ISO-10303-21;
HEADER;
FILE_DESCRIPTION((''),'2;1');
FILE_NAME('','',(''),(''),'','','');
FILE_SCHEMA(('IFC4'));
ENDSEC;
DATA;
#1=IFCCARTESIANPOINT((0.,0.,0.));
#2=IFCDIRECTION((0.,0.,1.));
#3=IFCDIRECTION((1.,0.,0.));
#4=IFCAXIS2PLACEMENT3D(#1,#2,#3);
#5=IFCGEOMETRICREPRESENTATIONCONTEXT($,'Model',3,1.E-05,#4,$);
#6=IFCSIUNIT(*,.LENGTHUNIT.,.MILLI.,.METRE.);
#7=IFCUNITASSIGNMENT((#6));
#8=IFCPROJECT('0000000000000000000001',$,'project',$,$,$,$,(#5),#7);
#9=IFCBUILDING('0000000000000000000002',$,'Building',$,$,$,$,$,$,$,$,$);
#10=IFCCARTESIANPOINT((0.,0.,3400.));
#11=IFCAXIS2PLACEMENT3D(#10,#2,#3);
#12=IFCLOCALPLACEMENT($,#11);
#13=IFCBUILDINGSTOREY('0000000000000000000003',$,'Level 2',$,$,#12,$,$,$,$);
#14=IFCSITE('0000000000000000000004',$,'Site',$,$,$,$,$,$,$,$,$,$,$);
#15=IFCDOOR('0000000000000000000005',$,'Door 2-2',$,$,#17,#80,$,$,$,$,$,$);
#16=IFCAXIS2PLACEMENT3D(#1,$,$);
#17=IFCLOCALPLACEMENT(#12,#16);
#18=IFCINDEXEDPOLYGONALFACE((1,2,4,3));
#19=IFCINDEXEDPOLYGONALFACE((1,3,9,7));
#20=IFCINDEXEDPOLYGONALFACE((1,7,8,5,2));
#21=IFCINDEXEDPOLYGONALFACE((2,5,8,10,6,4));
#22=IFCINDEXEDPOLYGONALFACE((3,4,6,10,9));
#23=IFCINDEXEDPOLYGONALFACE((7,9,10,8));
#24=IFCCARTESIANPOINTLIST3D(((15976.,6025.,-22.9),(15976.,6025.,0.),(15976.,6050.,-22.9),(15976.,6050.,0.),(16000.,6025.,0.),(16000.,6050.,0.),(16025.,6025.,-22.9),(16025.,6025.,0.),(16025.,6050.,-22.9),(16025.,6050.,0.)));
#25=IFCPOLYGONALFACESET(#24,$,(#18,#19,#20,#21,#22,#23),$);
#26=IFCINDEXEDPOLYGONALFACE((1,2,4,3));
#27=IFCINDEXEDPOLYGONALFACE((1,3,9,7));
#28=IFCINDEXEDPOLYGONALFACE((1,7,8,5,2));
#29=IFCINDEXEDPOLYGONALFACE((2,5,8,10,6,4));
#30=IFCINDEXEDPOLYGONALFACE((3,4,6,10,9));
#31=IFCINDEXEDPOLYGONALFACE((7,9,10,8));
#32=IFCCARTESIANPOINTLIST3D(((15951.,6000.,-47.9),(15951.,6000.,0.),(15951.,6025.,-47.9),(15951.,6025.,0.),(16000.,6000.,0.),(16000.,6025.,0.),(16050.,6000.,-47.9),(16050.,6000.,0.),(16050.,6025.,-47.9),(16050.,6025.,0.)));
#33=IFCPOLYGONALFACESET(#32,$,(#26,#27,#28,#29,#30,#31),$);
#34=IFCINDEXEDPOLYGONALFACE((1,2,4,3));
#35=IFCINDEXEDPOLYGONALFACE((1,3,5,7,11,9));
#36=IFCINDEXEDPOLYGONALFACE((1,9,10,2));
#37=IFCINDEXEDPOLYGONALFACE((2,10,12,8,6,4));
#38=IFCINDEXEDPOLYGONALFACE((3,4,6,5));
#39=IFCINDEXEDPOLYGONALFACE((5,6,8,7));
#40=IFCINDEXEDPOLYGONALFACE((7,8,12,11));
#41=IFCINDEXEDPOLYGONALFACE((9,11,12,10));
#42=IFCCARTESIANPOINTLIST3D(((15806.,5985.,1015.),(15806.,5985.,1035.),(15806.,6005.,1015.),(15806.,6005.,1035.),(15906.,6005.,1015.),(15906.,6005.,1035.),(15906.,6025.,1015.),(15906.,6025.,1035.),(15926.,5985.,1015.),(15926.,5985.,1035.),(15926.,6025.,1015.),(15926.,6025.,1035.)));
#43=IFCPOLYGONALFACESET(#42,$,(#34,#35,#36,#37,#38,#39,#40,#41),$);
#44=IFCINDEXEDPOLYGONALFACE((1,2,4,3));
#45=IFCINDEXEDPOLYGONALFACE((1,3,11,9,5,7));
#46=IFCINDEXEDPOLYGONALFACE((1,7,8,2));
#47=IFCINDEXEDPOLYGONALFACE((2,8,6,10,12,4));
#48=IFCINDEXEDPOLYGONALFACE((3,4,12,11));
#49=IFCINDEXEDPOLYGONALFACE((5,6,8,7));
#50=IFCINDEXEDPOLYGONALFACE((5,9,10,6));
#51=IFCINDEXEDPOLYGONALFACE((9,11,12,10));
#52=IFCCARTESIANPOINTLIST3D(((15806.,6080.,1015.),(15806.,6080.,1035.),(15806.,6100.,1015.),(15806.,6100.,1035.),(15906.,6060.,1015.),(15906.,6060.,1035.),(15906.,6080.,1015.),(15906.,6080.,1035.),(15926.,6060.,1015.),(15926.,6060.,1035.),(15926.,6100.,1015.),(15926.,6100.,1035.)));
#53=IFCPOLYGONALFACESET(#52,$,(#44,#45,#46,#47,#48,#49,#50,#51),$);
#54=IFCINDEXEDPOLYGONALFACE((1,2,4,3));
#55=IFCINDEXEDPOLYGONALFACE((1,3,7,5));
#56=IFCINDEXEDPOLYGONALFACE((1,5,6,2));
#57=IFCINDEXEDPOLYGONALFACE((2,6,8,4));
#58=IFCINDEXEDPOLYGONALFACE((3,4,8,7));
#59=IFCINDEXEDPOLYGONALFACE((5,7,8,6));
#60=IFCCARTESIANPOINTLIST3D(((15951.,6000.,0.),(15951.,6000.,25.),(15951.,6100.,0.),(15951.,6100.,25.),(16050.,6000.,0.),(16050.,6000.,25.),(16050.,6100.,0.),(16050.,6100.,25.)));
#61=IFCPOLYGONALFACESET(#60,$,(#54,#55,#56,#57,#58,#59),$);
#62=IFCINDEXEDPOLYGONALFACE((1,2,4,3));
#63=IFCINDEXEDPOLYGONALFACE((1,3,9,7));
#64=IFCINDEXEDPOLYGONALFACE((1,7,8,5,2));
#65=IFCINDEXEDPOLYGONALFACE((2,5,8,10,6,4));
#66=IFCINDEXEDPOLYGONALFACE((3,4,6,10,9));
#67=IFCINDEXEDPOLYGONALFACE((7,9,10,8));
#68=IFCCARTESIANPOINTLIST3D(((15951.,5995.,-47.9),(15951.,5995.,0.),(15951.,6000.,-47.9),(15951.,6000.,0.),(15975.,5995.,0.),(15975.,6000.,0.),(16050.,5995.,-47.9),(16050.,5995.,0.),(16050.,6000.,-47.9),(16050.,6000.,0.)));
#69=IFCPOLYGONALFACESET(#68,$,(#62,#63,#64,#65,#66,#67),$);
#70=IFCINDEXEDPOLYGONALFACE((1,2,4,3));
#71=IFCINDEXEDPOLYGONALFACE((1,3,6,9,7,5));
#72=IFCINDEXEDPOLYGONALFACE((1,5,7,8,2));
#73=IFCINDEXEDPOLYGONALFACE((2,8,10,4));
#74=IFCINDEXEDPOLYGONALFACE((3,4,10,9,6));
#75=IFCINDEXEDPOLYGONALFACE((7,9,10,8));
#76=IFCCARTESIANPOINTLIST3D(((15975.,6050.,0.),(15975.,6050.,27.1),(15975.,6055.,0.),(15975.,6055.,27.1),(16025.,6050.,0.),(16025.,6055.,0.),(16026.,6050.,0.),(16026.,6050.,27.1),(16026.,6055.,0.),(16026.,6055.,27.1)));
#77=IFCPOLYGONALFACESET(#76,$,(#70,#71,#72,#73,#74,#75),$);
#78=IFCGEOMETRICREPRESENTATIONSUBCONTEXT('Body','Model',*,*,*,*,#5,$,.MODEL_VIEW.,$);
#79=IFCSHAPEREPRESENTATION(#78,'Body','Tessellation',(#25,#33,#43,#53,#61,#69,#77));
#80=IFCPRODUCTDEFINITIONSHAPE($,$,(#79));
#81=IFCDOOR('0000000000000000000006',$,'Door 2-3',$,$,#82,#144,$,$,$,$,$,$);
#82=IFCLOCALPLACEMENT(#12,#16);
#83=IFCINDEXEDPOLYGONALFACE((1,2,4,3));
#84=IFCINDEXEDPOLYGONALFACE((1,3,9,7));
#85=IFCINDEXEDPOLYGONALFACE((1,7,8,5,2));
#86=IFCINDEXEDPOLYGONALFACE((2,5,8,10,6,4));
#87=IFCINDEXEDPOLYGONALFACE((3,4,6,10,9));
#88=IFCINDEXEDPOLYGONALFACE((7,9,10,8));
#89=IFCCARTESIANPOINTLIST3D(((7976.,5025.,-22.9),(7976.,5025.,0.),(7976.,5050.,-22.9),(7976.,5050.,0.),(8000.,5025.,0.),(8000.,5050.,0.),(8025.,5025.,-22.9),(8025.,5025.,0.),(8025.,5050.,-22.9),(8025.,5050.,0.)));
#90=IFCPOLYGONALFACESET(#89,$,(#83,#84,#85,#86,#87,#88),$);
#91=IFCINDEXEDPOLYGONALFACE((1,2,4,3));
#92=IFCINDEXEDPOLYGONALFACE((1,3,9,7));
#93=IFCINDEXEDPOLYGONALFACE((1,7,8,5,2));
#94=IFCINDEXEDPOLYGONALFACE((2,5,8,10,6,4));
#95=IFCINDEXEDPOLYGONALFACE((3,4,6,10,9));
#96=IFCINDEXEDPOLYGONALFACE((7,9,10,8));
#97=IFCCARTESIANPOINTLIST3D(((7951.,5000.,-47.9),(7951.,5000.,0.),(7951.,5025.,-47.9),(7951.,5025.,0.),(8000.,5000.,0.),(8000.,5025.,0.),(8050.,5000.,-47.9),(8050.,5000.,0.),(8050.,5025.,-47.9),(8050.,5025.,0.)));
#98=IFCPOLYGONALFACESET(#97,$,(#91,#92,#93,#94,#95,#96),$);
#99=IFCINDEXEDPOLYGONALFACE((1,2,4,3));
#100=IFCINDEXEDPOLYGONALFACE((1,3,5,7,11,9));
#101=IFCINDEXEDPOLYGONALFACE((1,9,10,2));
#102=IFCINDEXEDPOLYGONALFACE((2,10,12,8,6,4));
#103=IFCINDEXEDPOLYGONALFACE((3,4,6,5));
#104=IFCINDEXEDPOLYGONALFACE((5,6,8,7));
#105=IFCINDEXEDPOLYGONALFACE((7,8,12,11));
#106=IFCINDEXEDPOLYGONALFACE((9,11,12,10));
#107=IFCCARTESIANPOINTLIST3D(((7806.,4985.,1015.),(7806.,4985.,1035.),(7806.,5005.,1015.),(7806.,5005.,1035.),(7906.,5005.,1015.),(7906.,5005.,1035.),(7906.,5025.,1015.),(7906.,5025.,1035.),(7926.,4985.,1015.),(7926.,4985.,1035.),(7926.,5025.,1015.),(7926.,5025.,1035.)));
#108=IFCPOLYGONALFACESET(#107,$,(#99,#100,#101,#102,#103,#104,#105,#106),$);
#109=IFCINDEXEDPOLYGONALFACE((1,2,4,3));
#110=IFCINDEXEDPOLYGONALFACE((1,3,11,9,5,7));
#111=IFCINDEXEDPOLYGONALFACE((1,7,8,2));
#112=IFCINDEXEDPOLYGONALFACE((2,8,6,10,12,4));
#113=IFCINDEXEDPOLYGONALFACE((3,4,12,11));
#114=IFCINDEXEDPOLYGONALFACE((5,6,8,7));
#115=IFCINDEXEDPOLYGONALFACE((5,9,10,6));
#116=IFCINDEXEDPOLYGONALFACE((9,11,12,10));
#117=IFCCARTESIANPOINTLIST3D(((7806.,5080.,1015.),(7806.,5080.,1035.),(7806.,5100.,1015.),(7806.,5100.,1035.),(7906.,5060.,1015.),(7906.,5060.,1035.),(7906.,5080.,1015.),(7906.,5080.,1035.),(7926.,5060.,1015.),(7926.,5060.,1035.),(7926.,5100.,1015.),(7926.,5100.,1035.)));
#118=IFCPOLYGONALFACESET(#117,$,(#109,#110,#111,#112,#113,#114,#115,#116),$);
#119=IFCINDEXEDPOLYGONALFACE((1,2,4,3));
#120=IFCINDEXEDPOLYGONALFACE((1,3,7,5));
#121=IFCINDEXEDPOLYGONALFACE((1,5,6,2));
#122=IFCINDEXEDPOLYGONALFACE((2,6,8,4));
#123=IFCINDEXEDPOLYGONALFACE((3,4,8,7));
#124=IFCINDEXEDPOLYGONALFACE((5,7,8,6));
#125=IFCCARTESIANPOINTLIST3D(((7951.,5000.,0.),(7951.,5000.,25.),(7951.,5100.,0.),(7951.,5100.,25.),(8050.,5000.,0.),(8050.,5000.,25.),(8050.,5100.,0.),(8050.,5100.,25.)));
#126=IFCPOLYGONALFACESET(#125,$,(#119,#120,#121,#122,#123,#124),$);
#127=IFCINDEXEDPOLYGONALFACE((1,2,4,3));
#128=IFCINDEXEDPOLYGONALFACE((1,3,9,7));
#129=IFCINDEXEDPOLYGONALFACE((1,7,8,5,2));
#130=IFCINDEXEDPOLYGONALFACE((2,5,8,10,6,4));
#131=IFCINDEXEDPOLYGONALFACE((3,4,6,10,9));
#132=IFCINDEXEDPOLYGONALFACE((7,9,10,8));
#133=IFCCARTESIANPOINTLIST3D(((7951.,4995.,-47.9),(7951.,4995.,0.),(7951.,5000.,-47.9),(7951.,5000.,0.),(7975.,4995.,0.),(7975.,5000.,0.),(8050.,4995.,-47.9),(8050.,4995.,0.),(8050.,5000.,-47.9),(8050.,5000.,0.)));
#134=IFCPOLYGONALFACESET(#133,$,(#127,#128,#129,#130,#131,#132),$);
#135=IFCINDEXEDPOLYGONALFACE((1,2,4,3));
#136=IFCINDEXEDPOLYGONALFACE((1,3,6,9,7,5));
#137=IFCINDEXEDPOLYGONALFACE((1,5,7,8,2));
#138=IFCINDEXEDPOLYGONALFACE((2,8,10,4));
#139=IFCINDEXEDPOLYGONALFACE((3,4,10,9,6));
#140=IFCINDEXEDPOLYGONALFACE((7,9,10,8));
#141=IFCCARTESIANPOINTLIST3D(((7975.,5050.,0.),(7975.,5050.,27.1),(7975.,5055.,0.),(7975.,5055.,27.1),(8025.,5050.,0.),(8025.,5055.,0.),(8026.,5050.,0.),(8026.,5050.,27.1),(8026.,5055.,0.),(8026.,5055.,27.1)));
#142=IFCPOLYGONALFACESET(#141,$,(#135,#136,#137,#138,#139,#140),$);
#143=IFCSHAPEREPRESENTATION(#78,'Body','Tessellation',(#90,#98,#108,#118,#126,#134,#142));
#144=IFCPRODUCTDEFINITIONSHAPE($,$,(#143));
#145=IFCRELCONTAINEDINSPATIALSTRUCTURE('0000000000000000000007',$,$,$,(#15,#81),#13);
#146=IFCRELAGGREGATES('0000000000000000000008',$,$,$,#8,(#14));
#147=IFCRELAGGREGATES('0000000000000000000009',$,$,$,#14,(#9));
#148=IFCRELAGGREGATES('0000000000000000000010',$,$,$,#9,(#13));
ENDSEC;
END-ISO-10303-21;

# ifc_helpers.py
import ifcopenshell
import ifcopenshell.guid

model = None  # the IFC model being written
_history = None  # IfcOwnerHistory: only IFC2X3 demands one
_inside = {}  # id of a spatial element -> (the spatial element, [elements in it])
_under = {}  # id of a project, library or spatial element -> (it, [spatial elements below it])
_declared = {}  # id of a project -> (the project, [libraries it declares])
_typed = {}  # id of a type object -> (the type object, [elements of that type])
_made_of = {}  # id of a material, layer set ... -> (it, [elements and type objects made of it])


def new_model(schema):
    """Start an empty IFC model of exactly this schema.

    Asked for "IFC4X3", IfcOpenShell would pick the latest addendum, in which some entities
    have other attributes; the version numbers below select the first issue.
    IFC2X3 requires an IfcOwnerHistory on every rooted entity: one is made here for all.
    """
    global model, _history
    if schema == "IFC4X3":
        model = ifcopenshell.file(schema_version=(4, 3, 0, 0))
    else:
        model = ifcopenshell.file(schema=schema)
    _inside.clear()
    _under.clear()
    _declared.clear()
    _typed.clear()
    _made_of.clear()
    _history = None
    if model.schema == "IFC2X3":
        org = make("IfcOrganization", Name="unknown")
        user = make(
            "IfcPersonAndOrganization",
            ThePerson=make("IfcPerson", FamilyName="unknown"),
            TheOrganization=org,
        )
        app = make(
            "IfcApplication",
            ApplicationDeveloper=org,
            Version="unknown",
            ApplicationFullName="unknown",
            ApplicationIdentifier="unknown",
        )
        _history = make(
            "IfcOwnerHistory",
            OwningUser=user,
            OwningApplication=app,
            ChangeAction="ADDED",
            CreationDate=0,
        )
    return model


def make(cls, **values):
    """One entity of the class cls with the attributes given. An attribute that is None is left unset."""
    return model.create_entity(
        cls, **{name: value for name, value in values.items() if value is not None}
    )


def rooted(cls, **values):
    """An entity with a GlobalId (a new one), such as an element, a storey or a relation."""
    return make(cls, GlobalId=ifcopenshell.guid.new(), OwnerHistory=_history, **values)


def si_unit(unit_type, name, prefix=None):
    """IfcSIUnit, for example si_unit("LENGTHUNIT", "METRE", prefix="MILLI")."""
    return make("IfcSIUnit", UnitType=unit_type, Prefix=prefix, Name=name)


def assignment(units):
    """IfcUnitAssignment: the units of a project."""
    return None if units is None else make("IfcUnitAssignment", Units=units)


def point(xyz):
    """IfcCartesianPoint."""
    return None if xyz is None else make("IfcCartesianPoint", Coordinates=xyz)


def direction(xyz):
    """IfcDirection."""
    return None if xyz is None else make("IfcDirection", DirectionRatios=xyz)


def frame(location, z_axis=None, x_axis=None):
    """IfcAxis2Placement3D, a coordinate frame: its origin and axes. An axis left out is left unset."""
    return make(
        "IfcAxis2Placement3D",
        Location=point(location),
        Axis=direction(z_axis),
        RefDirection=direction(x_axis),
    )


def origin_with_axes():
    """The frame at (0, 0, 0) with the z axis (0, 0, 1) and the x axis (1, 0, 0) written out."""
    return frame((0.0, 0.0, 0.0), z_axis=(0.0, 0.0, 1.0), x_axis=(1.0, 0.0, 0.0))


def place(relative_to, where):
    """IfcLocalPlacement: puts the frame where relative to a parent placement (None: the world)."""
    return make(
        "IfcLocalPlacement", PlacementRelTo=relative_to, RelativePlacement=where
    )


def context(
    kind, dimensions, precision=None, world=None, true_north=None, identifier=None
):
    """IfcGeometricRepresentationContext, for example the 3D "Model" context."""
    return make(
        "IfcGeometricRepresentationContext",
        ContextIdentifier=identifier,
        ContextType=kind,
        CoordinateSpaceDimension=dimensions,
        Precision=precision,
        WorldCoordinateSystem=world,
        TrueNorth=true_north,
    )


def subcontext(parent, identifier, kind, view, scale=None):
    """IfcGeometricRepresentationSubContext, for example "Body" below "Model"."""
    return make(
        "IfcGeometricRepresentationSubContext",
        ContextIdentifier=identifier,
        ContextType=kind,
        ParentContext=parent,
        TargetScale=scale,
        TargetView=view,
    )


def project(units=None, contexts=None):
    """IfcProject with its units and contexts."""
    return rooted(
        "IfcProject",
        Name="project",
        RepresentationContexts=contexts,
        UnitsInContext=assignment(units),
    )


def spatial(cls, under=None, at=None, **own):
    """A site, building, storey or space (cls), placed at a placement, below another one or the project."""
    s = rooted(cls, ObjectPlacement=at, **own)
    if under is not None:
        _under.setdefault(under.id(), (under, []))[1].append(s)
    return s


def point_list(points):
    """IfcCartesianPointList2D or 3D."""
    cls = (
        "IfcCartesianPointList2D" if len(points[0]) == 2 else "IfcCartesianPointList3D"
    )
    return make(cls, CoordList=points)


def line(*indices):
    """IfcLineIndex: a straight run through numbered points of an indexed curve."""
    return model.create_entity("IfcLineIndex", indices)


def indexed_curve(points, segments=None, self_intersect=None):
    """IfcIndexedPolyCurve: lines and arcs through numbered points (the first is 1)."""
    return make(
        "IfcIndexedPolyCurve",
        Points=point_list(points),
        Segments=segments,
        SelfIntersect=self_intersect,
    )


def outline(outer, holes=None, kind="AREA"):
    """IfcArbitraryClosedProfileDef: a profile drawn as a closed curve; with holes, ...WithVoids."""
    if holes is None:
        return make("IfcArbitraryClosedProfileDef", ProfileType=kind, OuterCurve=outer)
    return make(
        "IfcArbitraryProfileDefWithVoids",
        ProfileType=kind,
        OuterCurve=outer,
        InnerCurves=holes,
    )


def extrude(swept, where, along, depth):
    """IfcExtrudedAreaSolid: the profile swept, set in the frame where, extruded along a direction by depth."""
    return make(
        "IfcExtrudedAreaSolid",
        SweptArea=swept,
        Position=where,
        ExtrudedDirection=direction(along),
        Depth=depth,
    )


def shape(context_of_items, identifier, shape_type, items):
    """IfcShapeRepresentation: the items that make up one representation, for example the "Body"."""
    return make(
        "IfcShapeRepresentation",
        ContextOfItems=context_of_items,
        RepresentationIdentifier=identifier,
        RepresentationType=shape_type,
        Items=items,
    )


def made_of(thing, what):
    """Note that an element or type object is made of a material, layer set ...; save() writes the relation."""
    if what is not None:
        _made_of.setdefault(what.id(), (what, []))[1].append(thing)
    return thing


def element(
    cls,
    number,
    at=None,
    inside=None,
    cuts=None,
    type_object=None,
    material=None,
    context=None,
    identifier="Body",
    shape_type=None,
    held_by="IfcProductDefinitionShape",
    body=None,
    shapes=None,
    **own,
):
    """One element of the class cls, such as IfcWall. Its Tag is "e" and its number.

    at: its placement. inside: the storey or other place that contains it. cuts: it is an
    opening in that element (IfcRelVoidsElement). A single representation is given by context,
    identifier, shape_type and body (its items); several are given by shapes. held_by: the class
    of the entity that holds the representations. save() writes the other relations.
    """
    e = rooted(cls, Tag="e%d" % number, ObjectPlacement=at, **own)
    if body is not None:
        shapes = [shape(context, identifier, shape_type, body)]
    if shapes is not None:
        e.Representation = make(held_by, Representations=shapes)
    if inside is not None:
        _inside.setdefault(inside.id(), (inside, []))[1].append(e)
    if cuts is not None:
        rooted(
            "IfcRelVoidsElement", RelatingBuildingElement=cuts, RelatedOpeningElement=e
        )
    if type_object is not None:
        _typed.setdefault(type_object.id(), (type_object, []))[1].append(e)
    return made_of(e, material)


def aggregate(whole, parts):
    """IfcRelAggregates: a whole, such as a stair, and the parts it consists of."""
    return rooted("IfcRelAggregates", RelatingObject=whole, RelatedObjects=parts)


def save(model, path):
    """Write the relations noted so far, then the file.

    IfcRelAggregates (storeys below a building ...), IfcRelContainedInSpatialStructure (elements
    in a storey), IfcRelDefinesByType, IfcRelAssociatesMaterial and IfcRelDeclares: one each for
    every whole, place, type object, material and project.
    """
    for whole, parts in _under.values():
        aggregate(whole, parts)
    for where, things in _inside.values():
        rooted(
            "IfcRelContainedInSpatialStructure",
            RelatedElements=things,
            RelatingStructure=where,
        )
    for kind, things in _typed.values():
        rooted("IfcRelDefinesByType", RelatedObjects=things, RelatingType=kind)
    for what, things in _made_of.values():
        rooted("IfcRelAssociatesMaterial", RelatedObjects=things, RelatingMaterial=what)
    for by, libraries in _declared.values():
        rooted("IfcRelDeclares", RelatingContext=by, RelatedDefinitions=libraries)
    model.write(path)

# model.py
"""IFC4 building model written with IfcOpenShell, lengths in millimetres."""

from ifc_helpers import new_model, si_unit, frame, origin_with_axes, place, context, subcontext, project, spatial, line, indexed_curve, outline, extrude, element, save


model = new_model("IFC4")

# Units and contexts
model_context = context("Model", 3, precision=1e-05, world=origin_with_axes())
body_context = subcontext(model_context, "Body", "Model", "MODEL_VIEW")
ifc_project = project(units=[si_unit("LENGTHUNIT", "METRE", prefix="MILLI")], contexts=[model_context])

# Site, building, storey
site = spatial("IfcSite", under=ifc_project, Name="Site")
building = spatial("IfcBuilding", under=site, Name="Building")
storey_placement = place(None, frame((0.0, 0.0, 3400.0), z_axis=(0.0, 0.0, 1.0), x_axis=(1.0, 0.0, 0.0)))
storey = spatial("IfcBuildingStorey", under=building, at=storey_placement, Name="Level 2")

# Doors
door_1_placement = place(storey_placement, frame((16000.0, 6000.0, 0.0), z_axis=(0.0, 0.0, 1.0), x_axis=(1.0, 0.0, 0.0)))
element("IfcDoor", 1, at=door_1_placement, inside=storey, Name="Door 2-2", context=body_context, shape_type="SweptSolid", body=[
    extrude(outline(indexed_curve([(0.0, 0.0), (0.0, 2.1), (1.0, 2.1), (1.0, 0.0), (-24.0, 0.0), (-24.0, -22.9), (25.0, -22.9), (25.0, 0.0)], segments=[line(1, 2, 3, 4, 5, 6, 7, 8, 1)])), frame((0.0, 25.0, 0.0), z_axis=(0.0, -1.0, 0.0), x_axis=(1.0, 0.0, 0.0)), (0.0, 0.0, -1.0), 25.0),
    extrude(outline(indexed_curve([(0.0, 0.0), (0.0, 2.1), (1.0, 2.1), (1.0, 0.0), (-49.0, 0.0), (-49.0, -47.9), (50.0, -47.9), (50.0, 0.0)], segments=[line(1, 2, 3, 4, 5, 6, 7, 8, 1)])), frame((0.0, 0.0, 0.0), z_axis=(0.0, -1.0, 0.0), x_axis=(1.0, 0.0, 0.0)), (0.0, 0.0, -1.0), 25.0),
    extrude(outline(indexed_curve([(0.0, 0.0), (-49.0, 0.0), (-49.0, 35.0), (0.0, 35.0)], segments=[line(1, 2, 3, 4, 1)])), frame((25.0, 25.0, 25.0), z_axis=(0.0, 0.0, 1.0), x_axis=(1.0, 0.0, 0.0)), (0.0, 0.0, 1.0), -47.9),
    extrude(outline(indexed_curve([(0.0, 0.0), (0.0, -40.0), (-120.0, -40.0), (-120.0, -20.0), (-20.0, -20.0), (-20.0, 0.0)], segments=[line(1, 2, 3, 4, 5, 6, 1)])), frame((-74.0, 25.0, 1015.0), z_axis=(0.0, 0.0, 1.0), x_axis=(1.0, 0.0, 0.0)), (0.0, 0.0, 1.0), 20.0),
    extrude(outline(indexed_curve([(0.0, 0.0), (0.0, 40.0), (-120.0, 40.0), (-120.0, 20.0), (-20.0, 20.0), (-20.0, 0.0)], segments=[line(1, 2, 3, 4, 5, 6, 1)])), frame((-74.0, 60.0, 1015.0), z_axis=(0.0, 0.0, 1.0), x_axis=(1.0, 0.0, 0.0)), (0.0, 0.0, 1.0), 20.0),
    extrude(outline(indexed_curve([(0.0, 0.0), (-99.0, 0.0), (-99.0, 100.0), (0.0, 100.0)], segments=[line(1, 2, 3, 4, 1)])), frame((50.0, 0.0, 0.0), z_axis=(0.0, 0.0, 1.0), x_axis=(1.0, 0.0, 0.0)), (0.0, 0.0, 1.0), 25.0),
    extrude(outline(indexed_curve([(0.0, 0.0), (0.0, 27.1), (51.0, 27.1), (51.0, 0.0), (-24.0, 0.0), (-24.0, -47.9), (75.0, -47.9), (75.0, 0.0)], segments=[line(1, 2, 3, 4, 5, 6, 7, 8, 1)])), frame((-25.0, -5.0, 0.0), z_axis=(0.0, -1.0, 0.0), x_axis=(1.0, 0.0, 0.0)), (0.0, 0.0, -1.0), 5.0),
    extrude(outline(indexed_curve([(0.0, 0.0), (0.0, 27.1), (51.0, 27.1), (51.0, 0.0), (1.0, 0.0), (1.0, -22.9), (50.0, -22.9), (50.0, 0.0)], segments=[line(1, 2, 3, 4, 5, 6, 7, 8, 1)])), frame((-25.0, 50.0, 0.0), z_axis=(0.0, -1.0, 0.0), x_axis=(1.0, 0.0, 0.0)), (0.0, 0.0, -1.0), 5.0),
])
door_2_placement = place(storey_placement, frame((8000.0, 5000.0, 0.0), z_axis=(0.0, 0.0, 1.0), x_axis=(1.0, 0.0, 0.0)))
element("IfcDoor", 2, at=door_2_placement, inside=storey, Name="Door 2-3", context=body_context, shape_type="SweptSolid", body=[
    extrude(outline(indexed_curve([(0.0, 0.0), (0.0, 2.1), (1.0, 2.1), (1.0, 0.0), (-24.0, 0.0), (-24.0, -22.9), (25.0, -22.9), (25.0, 0.0)], segments=[line(1, 2, 3, 4, 5, 6, 7, 8, 1)])), frame((0.0, 25.0, 0.0), z_axis=(0.0, -1.0, 0.0), x_axis=(1.0, 0.0, 0.0)), (0.0, 0.0, -1.0), 25.0),
    extrude(outline(indexed_curve([(0.0, 0.0), (0.0, 2.1), (1.0, 2.1), (1.0, 0.0), (-49.0, 0.0), (-49.0, -47.9), (50.0, -47.9), (50.0, 0.0)], segments=[line(1, 2, 3, 4, 5, 6, 7, 8, 1)])), frame((0.0, 0.0, 0.0), z_axis=(0.0, -1.0, 0.0), x_axis=(1.0, 0.0, 0.0)), (0.0, 0.0, -1.0), 25.0),
    extrude(outline(indexed_curve([(0.0, 0.0), (-49.0, 0.0), (-49.0, 35.0), (0.0, 35.0)], segments=[line(1, 2, 3, 4, 1)])), frame((25.0, 25.0, 25.0), z_axis=(0.0, 0.0, 1.0), x_axis=(1.0, 0.0, 0.0)), (0.0, 0.0, 1.0), -47.9),
    extrude(outline(indexed_curve([(0.0, 0.0), (0.0, -40.0), (-120.0, -40.0), (-120.0, -20.0), (-20.0, -20.0), (-20.0, 0.0)], segments=[line(1, 2, 3, 4, 5, 6, 1)])), frame((-74.0, 25.0, 1015.0), z_axis=(0.0, 0.0, 1.0), x_axis=(1.0, 0.0, 0.0)), (0.0, 0.0, 1.0), 20.0),
    extrude(outline(indexed_curve([(0.0, 0.0), (0.0, 40.0), (-120.0, 40.0), (-120.0, 20.0), (-20.0, 20.0), (-20.0, 0.0)], segments=[line(1, 2, 3, 4, 5, 6, 1)])), frame((-74.0, 60.0, 1015.0), z_axis=(0.0, 0.0, 1.0), x_axis=(1.0, 0.0, 0.0)), (0.0, 0.0, 1.0), 20.0),
    extrude(outline(indexed_curve([(0.0, 0.0), (-99.0, 0.0), (-99.0, 100.0), (0.0, 100.0)], segments=[line(1, 2, 3, 4, 1)])), frame((50.0, 0.0, 0.0), z_axis=(0.0, 0.0, 1.0), x_axis=(1.0, 0.0, 0.0)), (0.0, 0.0, 1.0), 25.0),
    extrude(outline(indexed_curve([(0.0, 0.0), (0.0, 27.1), (51.0, 27.1), (51.0, 0.0), (-24.0, 0.0), (-24.0, -47.9), (75.0, -47.9), (75.0, 0.0)], segments=[line(1, 2, 3, 4, 5, 6, 7, 8, 1)])), frame((-25.0, -5.0, 0.0), z_axis=(0.0, -1.0, 0.0), x_axis=(1.0, 0.0, 0.0)), (0.0, 0.0, -1.0), 5.0),
    extrude(outline(indexed_curve([(0.0, 0.0), (0.0, 27.1), (51.0, 27.1), (51.0, 0.0), (1.0, 0.0), (1.0, -22.9), (50.0, -22.9), (50.0, 0.0)], segments=[line(1, 2, 3, 4, 5, 6, 7, 8, 1)])), frame((-25.0, 50.0, 0.0), z_axis=(0.0, -1.0, 0.0), x_axis=(1.0, 0.0, 0.0)), (0.0, 0.0, -1.0), 5.0),
])

save(model, "model.ifc")
